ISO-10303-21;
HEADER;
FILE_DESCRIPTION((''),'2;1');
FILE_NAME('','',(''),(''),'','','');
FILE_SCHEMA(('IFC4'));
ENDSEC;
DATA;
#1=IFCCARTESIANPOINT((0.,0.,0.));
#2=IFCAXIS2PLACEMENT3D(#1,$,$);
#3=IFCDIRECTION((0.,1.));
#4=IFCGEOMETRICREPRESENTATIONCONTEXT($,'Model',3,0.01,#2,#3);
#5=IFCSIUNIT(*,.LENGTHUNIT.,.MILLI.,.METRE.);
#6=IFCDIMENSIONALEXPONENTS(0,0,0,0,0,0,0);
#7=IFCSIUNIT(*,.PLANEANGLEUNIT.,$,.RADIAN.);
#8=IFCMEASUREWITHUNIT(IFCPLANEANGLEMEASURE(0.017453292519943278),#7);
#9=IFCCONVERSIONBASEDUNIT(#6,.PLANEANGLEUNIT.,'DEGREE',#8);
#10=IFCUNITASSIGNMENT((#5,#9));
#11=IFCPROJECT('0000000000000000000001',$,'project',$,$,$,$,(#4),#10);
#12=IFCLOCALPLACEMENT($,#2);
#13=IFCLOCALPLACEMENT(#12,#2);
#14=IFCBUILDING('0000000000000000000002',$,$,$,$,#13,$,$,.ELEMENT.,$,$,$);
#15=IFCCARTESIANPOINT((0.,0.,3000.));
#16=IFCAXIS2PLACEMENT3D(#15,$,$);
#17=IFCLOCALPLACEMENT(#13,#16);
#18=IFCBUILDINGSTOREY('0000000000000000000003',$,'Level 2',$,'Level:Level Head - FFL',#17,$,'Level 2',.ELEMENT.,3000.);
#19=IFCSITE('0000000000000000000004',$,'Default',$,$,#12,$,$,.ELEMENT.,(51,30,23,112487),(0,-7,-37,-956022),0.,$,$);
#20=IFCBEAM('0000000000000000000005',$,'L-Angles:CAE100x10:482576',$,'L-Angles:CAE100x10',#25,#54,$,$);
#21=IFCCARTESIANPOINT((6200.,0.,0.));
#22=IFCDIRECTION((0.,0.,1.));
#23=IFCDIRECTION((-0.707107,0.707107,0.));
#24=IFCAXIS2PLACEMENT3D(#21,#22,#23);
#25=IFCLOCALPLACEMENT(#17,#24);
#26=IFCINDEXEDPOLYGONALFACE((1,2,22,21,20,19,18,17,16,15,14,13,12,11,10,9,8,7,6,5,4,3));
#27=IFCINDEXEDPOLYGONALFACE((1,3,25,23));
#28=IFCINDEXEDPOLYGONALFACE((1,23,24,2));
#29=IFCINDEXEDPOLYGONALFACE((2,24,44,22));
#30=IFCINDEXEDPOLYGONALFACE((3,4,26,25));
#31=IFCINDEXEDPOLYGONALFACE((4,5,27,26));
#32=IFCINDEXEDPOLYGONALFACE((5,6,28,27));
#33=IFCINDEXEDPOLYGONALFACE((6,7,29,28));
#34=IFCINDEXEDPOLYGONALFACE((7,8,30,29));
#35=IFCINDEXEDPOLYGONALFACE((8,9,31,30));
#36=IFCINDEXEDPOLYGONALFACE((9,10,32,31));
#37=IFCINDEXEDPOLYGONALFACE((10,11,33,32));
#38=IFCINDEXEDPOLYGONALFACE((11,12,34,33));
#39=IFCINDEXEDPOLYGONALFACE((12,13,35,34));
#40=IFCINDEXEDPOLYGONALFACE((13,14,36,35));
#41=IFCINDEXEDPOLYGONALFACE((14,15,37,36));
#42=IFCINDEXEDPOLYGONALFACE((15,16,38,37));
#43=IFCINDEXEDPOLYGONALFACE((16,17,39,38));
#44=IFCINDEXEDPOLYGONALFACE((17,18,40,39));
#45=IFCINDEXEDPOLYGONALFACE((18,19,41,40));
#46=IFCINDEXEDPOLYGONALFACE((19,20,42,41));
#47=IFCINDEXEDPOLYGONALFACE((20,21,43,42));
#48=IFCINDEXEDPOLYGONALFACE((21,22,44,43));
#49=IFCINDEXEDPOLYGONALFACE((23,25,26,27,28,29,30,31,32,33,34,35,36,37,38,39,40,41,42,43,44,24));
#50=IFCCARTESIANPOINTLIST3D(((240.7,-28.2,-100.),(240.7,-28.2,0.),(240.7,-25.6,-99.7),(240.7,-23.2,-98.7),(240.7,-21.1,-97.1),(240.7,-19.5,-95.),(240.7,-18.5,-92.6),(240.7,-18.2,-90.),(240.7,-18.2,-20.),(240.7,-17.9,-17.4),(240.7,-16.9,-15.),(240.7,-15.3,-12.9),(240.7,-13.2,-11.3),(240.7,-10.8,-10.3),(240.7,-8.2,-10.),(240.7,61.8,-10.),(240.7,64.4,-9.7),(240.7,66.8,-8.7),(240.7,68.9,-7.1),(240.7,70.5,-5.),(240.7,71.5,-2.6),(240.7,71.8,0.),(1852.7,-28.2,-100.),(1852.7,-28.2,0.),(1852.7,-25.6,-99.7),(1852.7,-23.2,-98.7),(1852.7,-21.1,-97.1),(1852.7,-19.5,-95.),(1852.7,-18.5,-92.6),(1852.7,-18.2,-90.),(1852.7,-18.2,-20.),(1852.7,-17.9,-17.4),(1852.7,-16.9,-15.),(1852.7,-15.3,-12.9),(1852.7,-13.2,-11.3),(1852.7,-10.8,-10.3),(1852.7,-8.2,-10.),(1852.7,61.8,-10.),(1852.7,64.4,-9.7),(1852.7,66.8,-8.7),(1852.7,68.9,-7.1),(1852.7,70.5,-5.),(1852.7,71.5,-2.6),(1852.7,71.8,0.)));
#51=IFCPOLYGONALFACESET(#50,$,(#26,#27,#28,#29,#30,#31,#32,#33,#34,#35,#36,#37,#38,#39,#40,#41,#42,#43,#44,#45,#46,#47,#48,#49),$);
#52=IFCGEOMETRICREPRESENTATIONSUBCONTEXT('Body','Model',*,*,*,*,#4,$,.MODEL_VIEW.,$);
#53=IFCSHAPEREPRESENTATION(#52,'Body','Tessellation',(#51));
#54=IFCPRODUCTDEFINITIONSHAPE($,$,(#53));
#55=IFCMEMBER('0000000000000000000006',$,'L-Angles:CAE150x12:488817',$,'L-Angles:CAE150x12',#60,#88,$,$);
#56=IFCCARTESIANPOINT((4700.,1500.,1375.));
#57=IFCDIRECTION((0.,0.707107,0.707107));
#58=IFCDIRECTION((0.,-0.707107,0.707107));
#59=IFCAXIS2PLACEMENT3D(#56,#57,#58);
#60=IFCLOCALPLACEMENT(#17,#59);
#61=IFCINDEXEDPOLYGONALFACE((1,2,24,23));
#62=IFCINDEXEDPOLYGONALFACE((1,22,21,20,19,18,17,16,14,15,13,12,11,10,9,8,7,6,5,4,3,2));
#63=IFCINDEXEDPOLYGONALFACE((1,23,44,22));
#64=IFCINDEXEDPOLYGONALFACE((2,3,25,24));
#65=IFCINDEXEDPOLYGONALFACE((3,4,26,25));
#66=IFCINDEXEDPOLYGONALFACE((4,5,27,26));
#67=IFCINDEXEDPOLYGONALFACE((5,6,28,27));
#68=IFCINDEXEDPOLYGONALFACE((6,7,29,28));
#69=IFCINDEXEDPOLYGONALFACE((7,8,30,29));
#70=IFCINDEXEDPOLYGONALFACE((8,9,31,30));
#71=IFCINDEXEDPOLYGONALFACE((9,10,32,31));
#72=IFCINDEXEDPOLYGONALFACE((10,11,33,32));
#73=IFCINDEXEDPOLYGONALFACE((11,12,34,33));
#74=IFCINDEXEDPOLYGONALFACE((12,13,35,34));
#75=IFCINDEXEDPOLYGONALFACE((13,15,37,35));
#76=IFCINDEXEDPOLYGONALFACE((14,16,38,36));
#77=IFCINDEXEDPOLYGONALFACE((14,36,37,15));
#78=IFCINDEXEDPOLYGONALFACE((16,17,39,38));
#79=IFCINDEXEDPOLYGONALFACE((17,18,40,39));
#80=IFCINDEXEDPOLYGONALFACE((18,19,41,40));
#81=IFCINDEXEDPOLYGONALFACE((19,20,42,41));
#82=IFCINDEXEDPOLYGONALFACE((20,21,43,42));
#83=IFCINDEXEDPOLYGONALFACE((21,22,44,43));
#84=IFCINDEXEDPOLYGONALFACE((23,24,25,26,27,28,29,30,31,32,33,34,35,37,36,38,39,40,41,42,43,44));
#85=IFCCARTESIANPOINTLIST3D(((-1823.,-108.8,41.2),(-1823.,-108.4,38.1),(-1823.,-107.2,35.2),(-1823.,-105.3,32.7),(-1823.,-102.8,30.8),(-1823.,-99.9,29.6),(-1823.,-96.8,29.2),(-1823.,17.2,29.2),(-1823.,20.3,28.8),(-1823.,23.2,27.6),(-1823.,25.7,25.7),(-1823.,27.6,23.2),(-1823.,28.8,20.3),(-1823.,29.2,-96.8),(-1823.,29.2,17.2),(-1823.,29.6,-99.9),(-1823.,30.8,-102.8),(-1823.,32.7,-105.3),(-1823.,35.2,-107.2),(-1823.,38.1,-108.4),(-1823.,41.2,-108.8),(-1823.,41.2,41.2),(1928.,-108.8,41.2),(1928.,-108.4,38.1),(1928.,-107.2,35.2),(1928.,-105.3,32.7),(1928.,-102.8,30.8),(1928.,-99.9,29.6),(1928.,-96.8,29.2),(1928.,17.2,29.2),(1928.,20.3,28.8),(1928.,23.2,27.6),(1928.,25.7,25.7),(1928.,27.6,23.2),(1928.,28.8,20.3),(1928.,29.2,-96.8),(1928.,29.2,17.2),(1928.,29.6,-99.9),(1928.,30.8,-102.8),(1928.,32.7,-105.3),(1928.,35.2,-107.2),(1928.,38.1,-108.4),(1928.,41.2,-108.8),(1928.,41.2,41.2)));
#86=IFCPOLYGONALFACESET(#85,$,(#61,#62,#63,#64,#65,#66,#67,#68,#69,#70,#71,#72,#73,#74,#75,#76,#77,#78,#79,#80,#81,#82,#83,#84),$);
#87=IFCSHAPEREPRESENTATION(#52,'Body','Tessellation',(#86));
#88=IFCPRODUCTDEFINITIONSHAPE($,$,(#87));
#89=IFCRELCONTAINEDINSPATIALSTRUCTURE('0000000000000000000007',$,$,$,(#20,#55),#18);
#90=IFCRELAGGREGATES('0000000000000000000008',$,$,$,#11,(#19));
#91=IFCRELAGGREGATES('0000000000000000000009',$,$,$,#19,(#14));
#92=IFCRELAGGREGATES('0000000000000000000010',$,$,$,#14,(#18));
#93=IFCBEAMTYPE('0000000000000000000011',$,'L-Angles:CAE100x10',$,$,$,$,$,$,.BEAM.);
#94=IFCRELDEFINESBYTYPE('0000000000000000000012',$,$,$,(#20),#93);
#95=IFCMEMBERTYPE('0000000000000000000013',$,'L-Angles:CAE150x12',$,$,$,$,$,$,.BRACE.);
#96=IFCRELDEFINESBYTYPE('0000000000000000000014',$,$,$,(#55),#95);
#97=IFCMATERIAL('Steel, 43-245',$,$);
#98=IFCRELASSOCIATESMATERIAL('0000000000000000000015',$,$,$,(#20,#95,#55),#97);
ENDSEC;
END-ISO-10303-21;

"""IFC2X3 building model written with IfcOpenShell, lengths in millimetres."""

from ifc_helpers import new_model, entity, si_unit, converted_unit, direction, frame, frame_2d, origin, place, context, subcontext, project, spatial, polyline, circle_curve, parameter, trimmed, segment, composite_curve, outline, extrude, source, transform, mapped, material, type_object, type_shapes, element, save


model = new_model("IFC2X3")

# Units and contexts
model_context = context("Model", 3, precision=0.01, world=origin(), true_north=direction((0.0, 1.0)))
body_context = subcontext(model_context, "Body", "Model", "MODEL_VIEW")
ifc_project = project(units=[si_unit("LENGTHUNIT", "METRE", prefix="MILLI"), converted_unit("PLANEANGLEUNIT", "DEGREE", entity("IfcPlaneAngleMeasure", 0.017453292519943278), si_unit("PLANEANGLEUNIT", "RADIAN"), dimensions=[0, 0, 0, 0, 0, 0, 0])], contexts=[model_context])

# Site, building, storey
site_placement = place(None, origin())
site = spatial("IfcSite", under=ifc_project, at=site_placement, Name="Default", CompositionType="ELEMENT", RefLatitude=(51, 30, 23, 112487), RefLongitude=(0, -7, -37, -956022), RefElevation=0.0)
building_placement = place(site_placement, origin())
building = spatial("IfcBuilding", under=site, at=building_placement, CompositionType="ELEMENT")
storey_placement = place(building_placement, frame((0.0, 0.0, 3000.0)))
storey = spatial("IfcBuildingStorey", under=building, at=storey_placement, Name="Level 2", ObjectType="Level:Level Head - FFL", LongName="Level 2", CompositionType="ELEMENT", Elevation=3000.0)

# Beam
ifc_material = material(Name="Steel, 43-245")
beam_type_1 = type_object("IfcBeamType", Name="L-Angles:CAE100x10", PredefinedType="BEAM")
beam_1_placement = place(storey_placement, frame((6200.0, 0.0, 0.0), z_axis=(0.0, 0.0, 1.0), x_axis=(-0.707107, 0.707107, 0.0)))
element("IfcBeam", 1, at=beam_1_placement, inside=storey, type_object=beam_type_1, material=ifc_material, Name="L-Angles:CAE100x10:482576", ObjectType="L-Angles:CAE100x10", context=body_context, shape_type="SweptSolid", body=[
    extrude(outline(composite_curve([segment(polyline([(-32.9, -32.9), (67.1, -32.9)]), True, "CONTINUOUS"), segment(trimmed(circle_curve(frame_2d((57.1, -32.9), x_axis=(1.0, 0.0)), 10.0), [parameter(0.0)], [parameter(90.0)], True, "PARAMETER"), True, "CONTINUOUS"), segment(polyline([(57.1, -22.9), (-12.9, -22.9)]), True, "CONTINUOUS"), segment(trimmed(circle_curve(frame_2d((-12.9, -12.9), x_axis=(0.0, -1.0)), 10.0), [parameter(270.0)], [parameter(0.0)], True, "PARAMETER"), False, "CONTINUOUS"), segment(polyline([(-22.9, -12.9), (-22.9, 57.1)]), True, "CONTINUOUS"), segment(trimmed(circle_curve(frame_2d((-32.9, 57.1), x_axis=(1.0, 0.0)), 10.0), [parameter(0.0)], [parameter(90.0)], True, "PARAMETER"), True, "CONTINUOUS"), segment(polyline([(-32.9, 67.1), (-32.9, -32.9)]), True, "CONTINUOUS")], self_intersect=False)), frame((240.7, 4.7, -32.9), z_axis=(1.0, 0.0, 0.0), x_axis=(0.0, 0.0, -1.0)), (0.0, 0.0, 1.0), 1612.0),
])

# Member
member_type = type_object("IfcMemberType", Name="L-Angles:CAE150x12", PredefinedType="BRACE", material=ifc_material)
shared_shape = source(origin(), body_context, "Body", "SweptSolid", [
    extrude(outline(composite_curve([segment(polyline([(-102.0, -48.0), (48.0, -48.0)]), True, "CONTINUOUS"), segment(polyline([(48.0, -48.0), (48.0, 102.0)]), True, "CONTINUOUS"), segment(trimmed(circle_curve(frame_2d((48.0, 90.0), x_axis=(0.0, 1.0)), 12.0), [parameter(0.0)], [parameter(90.0)], True, "PARAMETER"), True, "CONTINUOUS"), segment(polyline([(36.0, 90.0), (36.0, -24.0)]), True, "CONTINUOUS"), segment(trimmed(circle_curve(frame_2d((24.0, -24.0), x_axis=(1.0, 0.0)), 12.0), [parameter(270.0)], [parameter(0.0)], True, "PARAMETER"), False, "CONTINUOUS"), segment(polyline([(24.0, -36.0), (-90.0, -36.0)]), True, "CONTINUOUS"), segment(trimmed(circle_curve(frame_2d((-90.0, -48.0), x_axis=(0.0, 1.0)), 12.0), [parameter(0.0)], [parameter(90.0)], True, "PARAMETER"), True, "CONTINUOUS")], self_intersect=False)), frame((-1823.0, -6.8, -6.8), z_axis=(1.0, 0.0, 0.0), x_axis=(0.0, 0.0, 1.0)), (0.0, 0.0, 1.0), 3751.0),
])
type_shapes(member_type, [shared_shape])
member_placement = place(storey_placement, frame((4700.0, 1500.0, 1375.0), z_axis=(0.0, 0.707107, 0.707107), x_axis=(0.0, -0.707107, 0.707107)))
element("IfcMember", 2, at=member_placement, inside=storey, type_object=member_type, material=ifc_material, Name="L-Angles:CAE150x12:488817", ObjectType="L-Angles:CAE150x12", context=body_context, shape_type="MappedRepresentation", body=[
    mapped(shared_shape, transform((0.0, 0.0, 0.0), scale=1.0)),
])

save(model, "model.ifc")
